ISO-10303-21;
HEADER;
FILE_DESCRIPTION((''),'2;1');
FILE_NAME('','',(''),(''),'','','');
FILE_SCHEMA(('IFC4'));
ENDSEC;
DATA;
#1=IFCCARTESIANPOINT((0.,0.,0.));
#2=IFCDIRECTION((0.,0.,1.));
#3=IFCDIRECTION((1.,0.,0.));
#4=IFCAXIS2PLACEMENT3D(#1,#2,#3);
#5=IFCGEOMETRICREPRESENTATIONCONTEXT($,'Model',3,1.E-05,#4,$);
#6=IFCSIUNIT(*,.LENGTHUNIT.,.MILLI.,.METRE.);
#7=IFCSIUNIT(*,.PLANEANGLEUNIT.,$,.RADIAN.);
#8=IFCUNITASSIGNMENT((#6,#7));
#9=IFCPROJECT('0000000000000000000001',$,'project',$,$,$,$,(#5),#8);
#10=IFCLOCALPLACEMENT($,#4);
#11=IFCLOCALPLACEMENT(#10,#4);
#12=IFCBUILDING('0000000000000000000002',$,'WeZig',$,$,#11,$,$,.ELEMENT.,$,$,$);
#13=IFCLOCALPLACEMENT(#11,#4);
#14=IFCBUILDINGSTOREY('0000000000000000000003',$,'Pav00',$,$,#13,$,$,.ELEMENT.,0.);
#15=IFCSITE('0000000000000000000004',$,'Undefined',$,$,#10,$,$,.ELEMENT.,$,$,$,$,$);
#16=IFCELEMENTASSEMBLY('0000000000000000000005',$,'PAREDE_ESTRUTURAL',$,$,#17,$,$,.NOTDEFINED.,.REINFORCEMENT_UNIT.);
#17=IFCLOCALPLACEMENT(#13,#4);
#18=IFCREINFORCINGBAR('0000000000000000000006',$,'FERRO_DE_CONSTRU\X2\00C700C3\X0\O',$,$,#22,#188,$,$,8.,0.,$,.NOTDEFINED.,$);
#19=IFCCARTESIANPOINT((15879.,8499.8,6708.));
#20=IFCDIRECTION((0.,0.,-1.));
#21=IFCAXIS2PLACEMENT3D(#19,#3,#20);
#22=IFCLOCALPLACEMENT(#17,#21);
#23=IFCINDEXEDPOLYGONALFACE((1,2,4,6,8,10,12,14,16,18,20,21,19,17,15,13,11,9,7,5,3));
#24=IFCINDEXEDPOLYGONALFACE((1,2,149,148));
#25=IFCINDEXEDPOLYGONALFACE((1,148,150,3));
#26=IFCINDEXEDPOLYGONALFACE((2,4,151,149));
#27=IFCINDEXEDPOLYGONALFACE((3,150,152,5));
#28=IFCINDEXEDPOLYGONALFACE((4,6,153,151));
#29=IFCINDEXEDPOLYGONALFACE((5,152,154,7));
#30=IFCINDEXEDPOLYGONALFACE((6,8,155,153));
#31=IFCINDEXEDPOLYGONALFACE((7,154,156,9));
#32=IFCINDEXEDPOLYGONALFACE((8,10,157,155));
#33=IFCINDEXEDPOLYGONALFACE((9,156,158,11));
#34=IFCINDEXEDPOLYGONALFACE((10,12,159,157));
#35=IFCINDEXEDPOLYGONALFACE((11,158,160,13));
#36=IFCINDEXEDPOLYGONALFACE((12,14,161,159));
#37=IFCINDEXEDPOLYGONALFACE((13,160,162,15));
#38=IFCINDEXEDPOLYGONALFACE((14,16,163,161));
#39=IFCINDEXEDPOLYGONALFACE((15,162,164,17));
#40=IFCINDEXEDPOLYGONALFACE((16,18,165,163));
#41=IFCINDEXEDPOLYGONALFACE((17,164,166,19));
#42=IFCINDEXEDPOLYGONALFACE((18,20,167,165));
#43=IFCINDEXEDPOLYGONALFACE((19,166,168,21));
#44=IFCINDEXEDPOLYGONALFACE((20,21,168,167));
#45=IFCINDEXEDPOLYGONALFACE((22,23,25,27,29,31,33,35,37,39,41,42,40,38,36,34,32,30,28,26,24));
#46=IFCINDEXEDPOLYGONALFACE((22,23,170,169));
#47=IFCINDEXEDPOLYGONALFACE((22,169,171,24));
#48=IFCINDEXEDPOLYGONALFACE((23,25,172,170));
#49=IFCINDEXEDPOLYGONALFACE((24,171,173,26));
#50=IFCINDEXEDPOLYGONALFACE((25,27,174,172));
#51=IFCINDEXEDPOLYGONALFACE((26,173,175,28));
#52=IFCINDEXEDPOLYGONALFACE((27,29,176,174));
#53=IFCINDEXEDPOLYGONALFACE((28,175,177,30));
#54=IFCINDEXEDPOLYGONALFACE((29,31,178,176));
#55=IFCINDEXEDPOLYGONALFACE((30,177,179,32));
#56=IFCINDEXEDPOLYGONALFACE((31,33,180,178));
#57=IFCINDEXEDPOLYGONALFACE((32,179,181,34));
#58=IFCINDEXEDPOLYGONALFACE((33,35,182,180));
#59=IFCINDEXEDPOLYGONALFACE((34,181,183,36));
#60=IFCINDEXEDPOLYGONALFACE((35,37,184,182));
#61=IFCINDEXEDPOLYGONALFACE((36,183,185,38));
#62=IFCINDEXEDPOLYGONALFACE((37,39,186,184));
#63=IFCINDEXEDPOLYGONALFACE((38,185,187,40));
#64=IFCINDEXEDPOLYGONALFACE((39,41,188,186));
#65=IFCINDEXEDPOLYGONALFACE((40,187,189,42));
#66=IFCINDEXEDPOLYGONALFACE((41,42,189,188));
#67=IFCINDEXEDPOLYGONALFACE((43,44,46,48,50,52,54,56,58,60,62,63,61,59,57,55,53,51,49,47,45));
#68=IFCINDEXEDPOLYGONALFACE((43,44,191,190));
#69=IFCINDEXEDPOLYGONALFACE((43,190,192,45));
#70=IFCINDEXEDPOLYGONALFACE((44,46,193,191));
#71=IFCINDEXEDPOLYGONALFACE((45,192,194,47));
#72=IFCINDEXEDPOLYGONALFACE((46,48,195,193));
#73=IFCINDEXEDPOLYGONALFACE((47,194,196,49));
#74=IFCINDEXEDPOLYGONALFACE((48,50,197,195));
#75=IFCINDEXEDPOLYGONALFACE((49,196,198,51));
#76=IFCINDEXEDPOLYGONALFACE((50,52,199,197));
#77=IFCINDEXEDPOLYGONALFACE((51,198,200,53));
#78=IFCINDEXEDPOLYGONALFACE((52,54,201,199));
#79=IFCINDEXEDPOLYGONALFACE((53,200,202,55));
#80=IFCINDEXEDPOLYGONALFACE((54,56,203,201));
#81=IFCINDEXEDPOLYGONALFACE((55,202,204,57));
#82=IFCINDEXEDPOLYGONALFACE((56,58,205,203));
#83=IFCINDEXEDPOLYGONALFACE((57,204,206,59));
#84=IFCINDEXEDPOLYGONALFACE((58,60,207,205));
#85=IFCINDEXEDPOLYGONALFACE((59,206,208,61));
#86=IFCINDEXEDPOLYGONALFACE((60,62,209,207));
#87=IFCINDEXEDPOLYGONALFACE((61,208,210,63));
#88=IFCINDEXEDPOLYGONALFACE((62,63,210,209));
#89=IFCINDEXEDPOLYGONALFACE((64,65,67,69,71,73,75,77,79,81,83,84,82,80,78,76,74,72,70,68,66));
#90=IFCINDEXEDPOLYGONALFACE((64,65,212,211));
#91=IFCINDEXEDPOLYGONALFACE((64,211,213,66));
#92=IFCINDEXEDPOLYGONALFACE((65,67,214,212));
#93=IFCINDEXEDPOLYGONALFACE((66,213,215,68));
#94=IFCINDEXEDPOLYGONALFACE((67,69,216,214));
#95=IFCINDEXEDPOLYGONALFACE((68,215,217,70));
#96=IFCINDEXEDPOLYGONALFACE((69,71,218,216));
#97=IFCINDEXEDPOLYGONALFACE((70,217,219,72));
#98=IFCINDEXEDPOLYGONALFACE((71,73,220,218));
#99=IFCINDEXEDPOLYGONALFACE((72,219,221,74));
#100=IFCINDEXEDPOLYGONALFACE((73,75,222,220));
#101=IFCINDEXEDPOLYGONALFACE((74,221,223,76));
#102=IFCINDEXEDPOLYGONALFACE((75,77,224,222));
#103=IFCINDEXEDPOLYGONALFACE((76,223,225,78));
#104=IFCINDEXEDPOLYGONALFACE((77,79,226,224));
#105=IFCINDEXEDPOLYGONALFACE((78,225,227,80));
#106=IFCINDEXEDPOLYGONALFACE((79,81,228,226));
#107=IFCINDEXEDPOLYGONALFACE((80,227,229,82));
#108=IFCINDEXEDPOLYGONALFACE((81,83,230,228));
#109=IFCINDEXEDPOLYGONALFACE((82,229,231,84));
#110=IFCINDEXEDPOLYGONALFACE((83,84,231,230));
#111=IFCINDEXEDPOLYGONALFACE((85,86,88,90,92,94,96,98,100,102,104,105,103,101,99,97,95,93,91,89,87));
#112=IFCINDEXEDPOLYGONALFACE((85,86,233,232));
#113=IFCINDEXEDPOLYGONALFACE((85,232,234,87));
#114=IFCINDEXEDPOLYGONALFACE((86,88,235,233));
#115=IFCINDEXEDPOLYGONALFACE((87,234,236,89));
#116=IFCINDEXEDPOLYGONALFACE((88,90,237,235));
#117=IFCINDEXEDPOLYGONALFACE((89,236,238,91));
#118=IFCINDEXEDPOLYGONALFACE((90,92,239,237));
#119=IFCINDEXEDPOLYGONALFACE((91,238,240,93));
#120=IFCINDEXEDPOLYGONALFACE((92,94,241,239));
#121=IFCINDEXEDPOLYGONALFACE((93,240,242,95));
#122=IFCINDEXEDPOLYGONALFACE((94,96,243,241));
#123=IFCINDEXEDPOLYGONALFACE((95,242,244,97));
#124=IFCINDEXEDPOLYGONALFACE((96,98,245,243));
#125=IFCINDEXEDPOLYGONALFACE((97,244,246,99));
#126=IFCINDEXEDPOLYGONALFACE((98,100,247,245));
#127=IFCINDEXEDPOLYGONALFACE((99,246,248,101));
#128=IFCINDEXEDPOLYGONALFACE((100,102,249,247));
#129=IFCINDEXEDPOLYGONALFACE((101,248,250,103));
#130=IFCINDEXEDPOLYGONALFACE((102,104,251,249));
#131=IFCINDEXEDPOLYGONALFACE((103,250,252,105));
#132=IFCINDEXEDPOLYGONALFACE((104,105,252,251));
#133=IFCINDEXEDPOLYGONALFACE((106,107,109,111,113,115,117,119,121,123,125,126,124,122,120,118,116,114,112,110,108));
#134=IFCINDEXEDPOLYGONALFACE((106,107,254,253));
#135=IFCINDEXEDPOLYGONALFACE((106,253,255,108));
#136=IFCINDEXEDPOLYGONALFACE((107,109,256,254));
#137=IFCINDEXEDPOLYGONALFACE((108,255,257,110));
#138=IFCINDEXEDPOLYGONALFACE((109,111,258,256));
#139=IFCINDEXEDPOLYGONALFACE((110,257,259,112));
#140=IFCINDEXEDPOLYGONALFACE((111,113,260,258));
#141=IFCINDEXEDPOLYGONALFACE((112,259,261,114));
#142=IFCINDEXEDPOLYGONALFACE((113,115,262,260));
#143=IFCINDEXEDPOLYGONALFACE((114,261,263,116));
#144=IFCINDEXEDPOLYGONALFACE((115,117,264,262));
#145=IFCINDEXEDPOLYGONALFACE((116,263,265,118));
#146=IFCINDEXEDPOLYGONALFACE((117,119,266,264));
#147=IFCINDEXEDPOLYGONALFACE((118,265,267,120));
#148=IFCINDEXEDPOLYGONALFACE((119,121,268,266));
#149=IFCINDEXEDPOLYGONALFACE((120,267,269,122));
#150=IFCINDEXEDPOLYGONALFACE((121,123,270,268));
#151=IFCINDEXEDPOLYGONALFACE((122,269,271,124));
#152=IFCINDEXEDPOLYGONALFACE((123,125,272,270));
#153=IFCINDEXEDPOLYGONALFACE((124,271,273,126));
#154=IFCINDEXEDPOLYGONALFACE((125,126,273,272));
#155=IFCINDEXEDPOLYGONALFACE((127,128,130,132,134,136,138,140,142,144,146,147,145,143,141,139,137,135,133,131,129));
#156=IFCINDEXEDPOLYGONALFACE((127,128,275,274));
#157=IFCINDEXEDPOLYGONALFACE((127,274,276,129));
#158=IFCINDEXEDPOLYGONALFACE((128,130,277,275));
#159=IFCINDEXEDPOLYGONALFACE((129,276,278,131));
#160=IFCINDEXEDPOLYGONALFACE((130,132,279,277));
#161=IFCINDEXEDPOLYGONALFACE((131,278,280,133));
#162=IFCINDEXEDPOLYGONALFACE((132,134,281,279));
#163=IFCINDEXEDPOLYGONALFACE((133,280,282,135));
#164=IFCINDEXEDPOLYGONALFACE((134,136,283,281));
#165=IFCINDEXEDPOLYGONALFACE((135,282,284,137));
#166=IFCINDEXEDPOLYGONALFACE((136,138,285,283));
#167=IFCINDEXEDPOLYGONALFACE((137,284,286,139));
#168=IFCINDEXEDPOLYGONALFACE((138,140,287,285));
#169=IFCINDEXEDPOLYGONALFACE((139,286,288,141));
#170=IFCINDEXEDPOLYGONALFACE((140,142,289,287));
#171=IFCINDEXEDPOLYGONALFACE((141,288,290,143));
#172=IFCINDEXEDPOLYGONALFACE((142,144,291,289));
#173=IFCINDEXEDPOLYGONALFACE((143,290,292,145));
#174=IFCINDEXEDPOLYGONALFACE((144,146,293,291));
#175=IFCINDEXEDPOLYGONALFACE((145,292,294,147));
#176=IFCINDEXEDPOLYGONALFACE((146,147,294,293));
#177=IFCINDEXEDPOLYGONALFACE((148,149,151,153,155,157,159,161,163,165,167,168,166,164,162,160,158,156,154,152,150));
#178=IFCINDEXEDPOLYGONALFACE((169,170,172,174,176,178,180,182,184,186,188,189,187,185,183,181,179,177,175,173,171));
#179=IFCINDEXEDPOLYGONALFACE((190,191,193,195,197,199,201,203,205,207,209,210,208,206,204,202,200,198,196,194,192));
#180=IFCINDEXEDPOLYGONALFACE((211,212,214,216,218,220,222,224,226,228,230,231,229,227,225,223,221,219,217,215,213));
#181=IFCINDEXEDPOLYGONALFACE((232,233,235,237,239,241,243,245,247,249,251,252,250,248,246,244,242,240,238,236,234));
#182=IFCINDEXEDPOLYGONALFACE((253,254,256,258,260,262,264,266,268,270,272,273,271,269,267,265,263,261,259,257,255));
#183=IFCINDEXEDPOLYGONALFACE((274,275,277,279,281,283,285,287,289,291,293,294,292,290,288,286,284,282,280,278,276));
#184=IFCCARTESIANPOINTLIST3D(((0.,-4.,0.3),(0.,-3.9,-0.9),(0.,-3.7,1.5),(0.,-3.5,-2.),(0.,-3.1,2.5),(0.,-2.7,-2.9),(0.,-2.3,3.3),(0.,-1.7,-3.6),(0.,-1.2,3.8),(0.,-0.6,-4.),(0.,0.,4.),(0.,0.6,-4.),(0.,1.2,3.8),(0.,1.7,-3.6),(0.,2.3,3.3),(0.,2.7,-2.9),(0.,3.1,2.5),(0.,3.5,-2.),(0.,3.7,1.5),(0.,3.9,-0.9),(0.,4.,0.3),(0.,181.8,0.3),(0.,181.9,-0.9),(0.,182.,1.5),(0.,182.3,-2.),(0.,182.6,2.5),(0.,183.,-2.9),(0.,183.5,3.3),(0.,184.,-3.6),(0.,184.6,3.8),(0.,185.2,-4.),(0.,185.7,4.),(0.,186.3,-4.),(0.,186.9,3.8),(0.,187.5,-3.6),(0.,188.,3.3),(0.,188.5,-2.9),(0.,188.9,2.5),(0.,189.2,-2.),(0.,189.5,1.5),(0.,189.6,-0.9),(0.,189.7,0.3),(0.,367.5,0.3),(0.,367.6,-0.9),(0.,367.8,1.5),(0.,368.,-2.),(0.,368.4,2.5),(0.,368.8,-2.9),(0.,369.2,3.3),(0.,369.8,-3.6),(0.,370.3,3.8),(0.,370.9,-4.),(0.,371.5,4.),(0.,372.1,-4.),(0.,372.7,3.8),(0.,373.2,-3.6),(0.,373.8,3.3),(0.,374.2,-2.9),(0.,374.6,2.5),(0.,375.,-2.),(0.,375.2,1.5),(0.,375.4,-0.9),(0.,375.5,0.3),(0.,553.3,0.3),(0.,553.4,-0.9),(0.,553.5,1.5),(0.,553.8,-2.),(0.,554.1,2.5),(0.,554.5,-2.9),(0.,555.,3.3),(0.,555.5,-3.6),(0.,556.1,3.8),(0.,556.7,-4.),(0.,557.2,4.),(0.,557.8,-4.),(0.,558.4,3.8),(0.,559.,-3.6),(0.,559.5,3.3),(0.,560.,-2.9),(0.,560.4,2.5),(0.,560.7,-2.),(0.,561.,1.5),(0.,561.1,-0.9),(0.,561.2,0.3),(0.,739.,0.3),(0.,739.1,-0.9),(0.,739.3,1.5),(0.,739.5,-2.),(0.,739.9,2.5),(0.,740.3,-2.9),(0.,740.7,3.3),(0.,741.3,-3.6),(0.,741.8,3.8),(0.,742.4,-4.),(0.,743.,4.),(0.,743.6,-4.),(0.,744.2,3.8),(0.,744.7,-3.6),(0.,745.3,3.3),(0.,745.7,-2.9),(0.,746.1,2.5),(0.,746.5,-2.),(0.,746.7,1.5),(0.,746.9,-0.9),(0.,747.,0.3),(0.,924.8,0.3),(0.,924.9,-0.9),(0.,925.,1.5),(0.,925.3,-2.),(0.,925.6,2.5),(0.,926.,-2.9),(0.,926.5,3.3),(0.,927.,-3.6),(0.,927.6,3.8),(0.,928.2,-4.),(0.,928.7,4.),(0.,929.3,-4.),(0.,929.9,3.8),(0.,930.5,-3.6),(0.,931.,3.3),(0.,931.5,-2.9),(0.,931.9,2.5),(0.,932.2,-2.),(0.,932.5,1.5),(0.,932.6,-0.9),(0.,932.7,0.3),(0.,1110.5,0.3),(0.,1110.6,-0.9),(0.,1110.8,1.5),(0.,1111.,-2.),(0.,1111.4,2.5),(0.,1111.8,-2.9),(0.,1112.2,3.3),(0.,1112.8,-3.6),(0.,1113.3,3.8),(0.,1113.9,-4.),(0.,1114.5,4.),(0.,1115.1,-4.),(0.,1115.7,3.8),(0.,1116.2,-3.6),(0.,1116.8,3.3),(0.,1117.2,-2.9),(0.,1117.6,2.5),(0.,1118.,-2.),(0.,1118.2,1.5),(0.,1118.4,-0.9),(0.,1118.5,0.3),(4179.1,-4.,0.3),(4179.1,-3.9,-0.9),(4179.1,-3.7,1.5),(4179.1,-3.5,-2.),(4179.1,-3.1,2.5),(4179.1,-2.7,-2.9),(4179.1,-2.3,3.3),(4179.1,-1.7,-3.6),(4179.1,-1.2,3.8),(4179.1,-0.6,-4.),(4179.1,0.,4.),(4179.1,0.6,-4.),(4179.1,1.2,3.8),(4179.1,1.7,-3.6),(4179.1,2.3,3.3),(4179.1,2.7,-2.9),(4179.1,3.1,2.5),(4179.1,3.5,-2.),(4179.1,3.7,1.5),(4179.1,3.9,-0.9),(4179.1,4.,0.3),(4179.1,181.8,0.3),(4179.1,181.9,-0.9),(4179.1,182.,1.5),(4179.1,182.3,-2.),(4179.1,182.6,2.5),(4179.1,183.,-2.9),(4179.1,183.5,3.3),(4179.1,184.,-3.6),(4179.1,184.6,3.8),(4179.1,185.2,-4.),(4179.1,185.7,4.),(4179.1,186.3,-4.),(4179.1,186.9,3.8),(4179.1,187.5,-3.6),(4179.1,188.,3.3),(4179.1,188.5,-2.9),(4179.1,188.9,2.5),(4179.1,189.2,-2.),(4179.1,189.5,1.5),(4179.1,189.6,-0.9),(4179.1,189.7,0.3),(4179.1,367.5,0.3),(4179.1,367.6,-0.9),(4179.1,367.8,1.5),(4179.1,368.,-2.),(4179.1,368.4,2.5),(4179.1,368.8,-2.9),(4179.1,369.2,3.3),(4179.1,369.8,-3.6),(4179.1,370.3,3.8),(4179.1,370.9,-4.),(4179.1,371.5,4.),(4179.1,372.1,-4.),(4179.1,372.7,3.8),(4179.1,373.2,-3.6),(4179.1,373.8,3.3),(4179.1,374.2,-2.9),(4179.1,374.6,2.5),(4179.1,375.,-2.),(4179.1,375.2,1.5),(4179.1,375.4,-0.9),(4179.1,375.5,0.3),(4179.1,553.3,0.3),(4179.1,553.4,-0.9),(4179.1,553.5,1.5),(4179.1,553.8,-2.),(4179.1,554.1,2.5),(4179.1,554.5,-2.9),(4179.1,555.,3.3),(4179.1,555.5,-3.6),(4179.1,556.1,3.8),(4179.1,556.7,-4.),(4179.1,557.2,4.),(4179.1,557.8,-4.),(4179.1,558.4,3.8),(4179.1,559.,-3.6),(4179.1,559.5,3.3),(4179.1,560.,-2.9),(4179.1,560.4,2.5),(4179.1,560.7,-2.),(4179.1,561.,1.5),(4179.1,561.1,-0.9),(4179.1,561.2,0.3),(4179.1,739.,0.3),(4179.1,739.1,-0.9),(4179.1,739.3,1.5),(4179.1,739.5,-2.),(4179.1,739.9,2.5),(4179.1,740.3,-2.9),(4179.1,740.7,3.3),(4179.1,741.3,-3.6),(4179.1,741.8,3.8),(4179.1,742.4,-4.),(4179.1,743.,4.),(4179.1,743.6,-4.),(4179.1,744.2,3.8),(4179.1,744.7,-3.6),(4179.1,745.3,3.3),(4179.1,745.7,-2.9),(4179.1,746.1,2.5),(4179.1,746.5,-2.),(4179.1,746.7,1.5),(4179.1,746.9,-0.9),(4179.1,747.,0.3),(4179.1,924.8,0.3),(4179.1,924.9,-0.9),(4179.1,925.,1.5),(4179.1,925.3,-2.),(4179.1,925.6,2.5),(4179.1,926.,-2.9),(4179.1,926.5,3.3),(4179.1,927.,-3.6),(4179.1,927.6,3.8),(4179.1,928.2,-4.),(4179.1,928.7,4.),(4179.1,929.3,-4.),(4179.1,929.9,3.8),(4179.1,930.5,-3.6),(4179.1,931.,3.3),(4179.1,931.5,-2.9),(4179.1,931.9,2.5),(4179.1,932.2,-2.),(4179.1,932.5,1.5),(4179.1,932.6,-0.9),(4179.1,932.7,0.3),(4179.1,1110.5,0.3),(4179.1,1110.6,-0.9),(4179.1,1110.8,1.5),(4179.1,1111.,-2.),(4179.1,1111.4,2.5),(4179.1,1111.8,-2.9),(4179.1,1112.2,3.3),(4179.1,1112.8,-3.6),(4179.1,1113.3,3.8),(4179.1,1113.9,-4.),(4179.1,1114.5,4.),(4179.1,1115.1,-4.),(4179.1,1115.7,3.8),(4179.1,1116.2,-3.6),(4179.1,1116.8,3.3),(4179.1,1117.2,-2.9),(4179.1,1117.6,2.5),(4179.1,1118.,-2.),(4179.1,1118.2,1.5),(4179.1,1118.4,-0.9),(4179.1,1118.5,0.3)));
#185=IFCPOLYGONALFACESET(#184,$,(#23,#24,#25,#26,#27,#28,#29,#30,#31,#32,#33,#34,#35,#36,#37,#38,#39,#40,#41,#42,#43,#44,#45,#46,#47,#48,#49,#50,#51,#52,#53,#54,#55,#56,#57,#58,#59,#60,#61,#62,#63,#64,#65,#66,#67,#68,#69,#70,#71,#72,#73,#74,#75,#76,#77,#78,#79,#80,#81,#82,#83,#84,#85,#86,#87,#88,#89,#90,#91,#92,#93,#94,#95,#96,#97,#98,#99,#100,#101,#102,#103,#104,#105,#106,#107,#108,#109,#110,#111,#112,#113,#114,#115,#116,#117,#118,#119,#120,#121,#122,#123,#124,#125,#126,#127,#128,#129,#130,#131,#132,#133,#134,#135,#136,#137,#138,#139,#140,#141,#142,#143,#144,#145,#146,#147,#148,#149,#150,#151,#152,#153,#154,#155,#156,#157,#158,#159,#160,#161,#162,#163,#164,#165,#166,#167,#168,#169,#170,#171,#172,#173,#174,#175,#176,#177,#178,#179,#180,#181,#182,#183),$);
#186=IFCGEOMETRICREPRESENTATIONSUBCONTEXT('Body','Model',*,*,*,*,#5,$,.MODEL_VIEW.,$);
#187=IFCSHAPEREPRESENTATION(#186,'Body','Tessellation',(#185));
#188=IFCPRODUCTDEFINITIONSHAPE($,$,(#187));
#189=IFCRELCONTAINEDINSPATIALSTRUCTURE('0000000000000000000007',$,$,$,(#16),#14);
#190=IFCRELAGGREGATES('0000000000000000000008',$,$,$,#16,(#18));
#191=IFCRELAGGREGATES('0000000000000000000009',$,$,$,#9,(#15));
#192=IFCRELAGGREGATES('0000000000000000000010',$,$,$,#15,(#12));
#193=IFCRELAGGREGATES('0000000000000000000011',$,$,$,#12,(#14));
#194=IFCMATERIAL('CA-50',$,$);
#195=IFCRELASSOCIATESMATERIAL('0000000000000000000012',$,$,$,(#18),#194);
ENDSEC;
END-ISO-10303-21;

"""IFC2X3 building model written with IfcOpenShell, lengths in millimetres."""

from ifc_helpers import new_model, entity, si_unit, frame, origin_with_axes, place, context, subcontext, project, spatial, source, transform, mapped, material, element, aggregate, save


model = new_model("IFC2X3")

# Units and contexts
model_context = context("Model", 3, precision=1e-05, world=origin_with_axes())
body_context = subcontext(model_context, "Body", "Model", "MODEL_VIEW")
ifc_project = project(units=[si_unit("LENGTHUNIT", "METRE", prefix="MILLI"), si_unit("PLANEANGLEUNIT", "RADIAN")], contexts=[model_context])

# Site, building, storey
site_placement = place(None, origin_with_axes())
site = spatial("IfcSite", under=ifc_project, at=site_placement, Name="Undefined", CompositionType="ELEMENT")
building_placement = place(site_placement, origin_with_axes())
building = spatial("IfcBuilding", under=site, at=building_placement, Name="WeZig", CompositionType="ELEMENT")
storey_placement = place(building_placement, origin_with_axes())
storey = spatial("IfcBuildingStorey", under=building, at=storey_placement, Name="Pav00", CompositionType="ELEMENT", Elevation=0.0)

# Element assembly
assembly_1_placement = place(storey_placement, origin_with_axes())
assembly_1 = element("IfcElementAssembly", 1, at=assembly_1_placement, inside=storey, Name="PAREDE_ESTRUTURAL", AssemblyPlace="NOTDEFINED", PredefinedType="REINFORCEMENT_UNIT")

# Reinforcing bar
ifc_material_1 = material(Name="CA-50")
shared_shape_1 = source(origin_with_axes(), body_context, "Body", "AdvancedSweptSolid", [
    entity("IfcSweptDiskSolid", entity("IfcTrimmedCurve", entity("IfcLine", entity("IfcCartesianPoint", [0.0, 0.0, 0.0]), entity("IfcVector", entity("IfcDirection", [1.0, 0.0, 0.0]), 1.0)), [entity("IfcParameterValue", 0.0)], [entity("IfcParameterValue", 4179.133111)], True, "PARAMETER"), 4.0, None, 0.0, 4179.1),
])
shared_shape_2 = source(origin_with_axes(), body_context, "Body", "AdvancedSweptSolid", [
    entity("IfcSweptDiskSolid", entity("IfcTrimmedCurve", entity("IfcLine", entity("IfcCartesianPoint", [0.0, 0.0, 0.0]), entity("IfcVector", entity("IfcDirection", [1.0, 0.0, 0.0]), 1.0)), [entity("IfcParameterValue", 0.0)], [entity("IfcParameterValue", 4179.133111)], True, "PARAMETER"), 4.0, None, 0.0, 4179.1),
])
shared_shape_3 = source(origin_with_axes(), body_context, "Body", "AdvancedSweptSolid", [
    entity("IfcSweptDiskSolid", entity("IfcTrimmedCurve", entity("IfcLine", entity("IfcCartesianPoint", [0.0, 0.0, 0.0]), entity("IfcVector", entity("IfcDirection", [1.0, 0.0, 0.0]), 1.0)), [entity("IfcParameterValue", 0.0)], [entity("IfcParameterValue", 4179.133111)], True, "PARAMETER"), 4.0, None, 0.0, 4179.1),
])
shared_shape_4 = source(origin_with_axes(), body_context, "Body", "AdvancedSweptSolid", [
    entity("IfcSweptDiskSolid", entity("IfcTrimmedCurve", entity("IfcLine", entity("IfcCartesianPoint", [0.0, 0.0, 0.0]), entity("IfcVector", entity("IfcDirection", [1.0, 0.0, 0.0]), 1.0)), [entity("IfcParameterValue", 0.0)], [entity("IfcParameterValue", 4179.133111)], True, "PARAMETER"), 4.0, None, 0.0, 4179.1),
])
shared_shape_5 = source(origin_with_axes(), body_context, "Body", "AdvancedSweptSolid", [
    entity("IfcSweptDiskSolid", entity("IfcTrimmedCurve", entity("IfcLine", entity("IfcCartesianPoint", [0.0, 0.0, 0.0]), entity("IfcVector", entity("IfcDirection", [1.0, 0.0, 0.0]), 1.0)), [entity("IfcParameterValue", 0.0)], [entity("IfcParameterValue", 4179.133111)], True, "PARAMETER"), 4.0, None, 0.0, 4179.1),
])
shared_shape_6 = source(origin_with_axes(), body_context, "Body", "AdvancedSweptSolid", [
    entity("IfcSweptDiskSolid", entity("IfcTrimmedCurve", entity("IfcLine", entity("IfcCartesianPoint", [0.0, 0.0, 0.0]), entity("IfcVector", entity("IfcDirection", [1.0, 0.0, 0.0]), 1.0)), [entity("IfcParameterValue", 0.0)], [entity("IfcParameterValue", 4179.133111)], True, "PARAMETER"), 4.0, None, 0.0, 4179.1),
])
shared_shape_7 = source(origin_with_axes(), body_context, "Body", "AdvancedSweptSolid", [
    entity("IfcSweptDiskSolid", entity("IfcTrimmedCurve", entity("IfcLine", entity("IfcCartesianPoint", [0.0, 0.0, 0.0]), entity("IfcVector", entity("IfcDirection", [1.0, 0.0, 0.0]), 1.0)), [entity("IfcParameterValue", 0.0)], [entity("IfcParameterValue", 4179.133111)], True, "PARAMETER"), 4.0, None, 0.0, 4179.1),
])
reinforcing_bar_1_placement = place(assembly_1_placement, frame((15879.0, 8499.8, 6708.0), z_axis=(1.0, 0.0, 0.0), x_axis=(0.0, 0.0, -1.0)))
reinforcing_bar_1 = element("IfcReinforcingBar", 2, at=reinforcing_bar_1_placement, material=ifc_material_1, Name="FERRO_DE_CONSTRUÇÃO", BarRole="NOTDEFINED", CrossSectionArea=0.0, NominalDiameter=8.0, context=body_context, shape_type="MappedRepresentation", body=[
    mapped(shared_shape_1, transform((0.0, 0.0, 0.0))),
    mapped(shared_shape_2, transform((0.0, 185.7, 0.0))),
    mapped(shared_shape_3, transform((0.0, 371.5, 0.0))),
    mapped(shared_shape_4, transform((0.0, 557.2, 0.0))),
    mapped(shared_shape_5, transform((0.0, 743.0, 0.0))),
    mapped(shared_shape_6, transform((0.0, 928.7, 0.0))),
    mapped(shared_shape_7, transform((0.0, 1114.5, 0.0))),
])
aggregate(assembly_1, [reinforcing_bar_1])

save(model, "model.ifc")
